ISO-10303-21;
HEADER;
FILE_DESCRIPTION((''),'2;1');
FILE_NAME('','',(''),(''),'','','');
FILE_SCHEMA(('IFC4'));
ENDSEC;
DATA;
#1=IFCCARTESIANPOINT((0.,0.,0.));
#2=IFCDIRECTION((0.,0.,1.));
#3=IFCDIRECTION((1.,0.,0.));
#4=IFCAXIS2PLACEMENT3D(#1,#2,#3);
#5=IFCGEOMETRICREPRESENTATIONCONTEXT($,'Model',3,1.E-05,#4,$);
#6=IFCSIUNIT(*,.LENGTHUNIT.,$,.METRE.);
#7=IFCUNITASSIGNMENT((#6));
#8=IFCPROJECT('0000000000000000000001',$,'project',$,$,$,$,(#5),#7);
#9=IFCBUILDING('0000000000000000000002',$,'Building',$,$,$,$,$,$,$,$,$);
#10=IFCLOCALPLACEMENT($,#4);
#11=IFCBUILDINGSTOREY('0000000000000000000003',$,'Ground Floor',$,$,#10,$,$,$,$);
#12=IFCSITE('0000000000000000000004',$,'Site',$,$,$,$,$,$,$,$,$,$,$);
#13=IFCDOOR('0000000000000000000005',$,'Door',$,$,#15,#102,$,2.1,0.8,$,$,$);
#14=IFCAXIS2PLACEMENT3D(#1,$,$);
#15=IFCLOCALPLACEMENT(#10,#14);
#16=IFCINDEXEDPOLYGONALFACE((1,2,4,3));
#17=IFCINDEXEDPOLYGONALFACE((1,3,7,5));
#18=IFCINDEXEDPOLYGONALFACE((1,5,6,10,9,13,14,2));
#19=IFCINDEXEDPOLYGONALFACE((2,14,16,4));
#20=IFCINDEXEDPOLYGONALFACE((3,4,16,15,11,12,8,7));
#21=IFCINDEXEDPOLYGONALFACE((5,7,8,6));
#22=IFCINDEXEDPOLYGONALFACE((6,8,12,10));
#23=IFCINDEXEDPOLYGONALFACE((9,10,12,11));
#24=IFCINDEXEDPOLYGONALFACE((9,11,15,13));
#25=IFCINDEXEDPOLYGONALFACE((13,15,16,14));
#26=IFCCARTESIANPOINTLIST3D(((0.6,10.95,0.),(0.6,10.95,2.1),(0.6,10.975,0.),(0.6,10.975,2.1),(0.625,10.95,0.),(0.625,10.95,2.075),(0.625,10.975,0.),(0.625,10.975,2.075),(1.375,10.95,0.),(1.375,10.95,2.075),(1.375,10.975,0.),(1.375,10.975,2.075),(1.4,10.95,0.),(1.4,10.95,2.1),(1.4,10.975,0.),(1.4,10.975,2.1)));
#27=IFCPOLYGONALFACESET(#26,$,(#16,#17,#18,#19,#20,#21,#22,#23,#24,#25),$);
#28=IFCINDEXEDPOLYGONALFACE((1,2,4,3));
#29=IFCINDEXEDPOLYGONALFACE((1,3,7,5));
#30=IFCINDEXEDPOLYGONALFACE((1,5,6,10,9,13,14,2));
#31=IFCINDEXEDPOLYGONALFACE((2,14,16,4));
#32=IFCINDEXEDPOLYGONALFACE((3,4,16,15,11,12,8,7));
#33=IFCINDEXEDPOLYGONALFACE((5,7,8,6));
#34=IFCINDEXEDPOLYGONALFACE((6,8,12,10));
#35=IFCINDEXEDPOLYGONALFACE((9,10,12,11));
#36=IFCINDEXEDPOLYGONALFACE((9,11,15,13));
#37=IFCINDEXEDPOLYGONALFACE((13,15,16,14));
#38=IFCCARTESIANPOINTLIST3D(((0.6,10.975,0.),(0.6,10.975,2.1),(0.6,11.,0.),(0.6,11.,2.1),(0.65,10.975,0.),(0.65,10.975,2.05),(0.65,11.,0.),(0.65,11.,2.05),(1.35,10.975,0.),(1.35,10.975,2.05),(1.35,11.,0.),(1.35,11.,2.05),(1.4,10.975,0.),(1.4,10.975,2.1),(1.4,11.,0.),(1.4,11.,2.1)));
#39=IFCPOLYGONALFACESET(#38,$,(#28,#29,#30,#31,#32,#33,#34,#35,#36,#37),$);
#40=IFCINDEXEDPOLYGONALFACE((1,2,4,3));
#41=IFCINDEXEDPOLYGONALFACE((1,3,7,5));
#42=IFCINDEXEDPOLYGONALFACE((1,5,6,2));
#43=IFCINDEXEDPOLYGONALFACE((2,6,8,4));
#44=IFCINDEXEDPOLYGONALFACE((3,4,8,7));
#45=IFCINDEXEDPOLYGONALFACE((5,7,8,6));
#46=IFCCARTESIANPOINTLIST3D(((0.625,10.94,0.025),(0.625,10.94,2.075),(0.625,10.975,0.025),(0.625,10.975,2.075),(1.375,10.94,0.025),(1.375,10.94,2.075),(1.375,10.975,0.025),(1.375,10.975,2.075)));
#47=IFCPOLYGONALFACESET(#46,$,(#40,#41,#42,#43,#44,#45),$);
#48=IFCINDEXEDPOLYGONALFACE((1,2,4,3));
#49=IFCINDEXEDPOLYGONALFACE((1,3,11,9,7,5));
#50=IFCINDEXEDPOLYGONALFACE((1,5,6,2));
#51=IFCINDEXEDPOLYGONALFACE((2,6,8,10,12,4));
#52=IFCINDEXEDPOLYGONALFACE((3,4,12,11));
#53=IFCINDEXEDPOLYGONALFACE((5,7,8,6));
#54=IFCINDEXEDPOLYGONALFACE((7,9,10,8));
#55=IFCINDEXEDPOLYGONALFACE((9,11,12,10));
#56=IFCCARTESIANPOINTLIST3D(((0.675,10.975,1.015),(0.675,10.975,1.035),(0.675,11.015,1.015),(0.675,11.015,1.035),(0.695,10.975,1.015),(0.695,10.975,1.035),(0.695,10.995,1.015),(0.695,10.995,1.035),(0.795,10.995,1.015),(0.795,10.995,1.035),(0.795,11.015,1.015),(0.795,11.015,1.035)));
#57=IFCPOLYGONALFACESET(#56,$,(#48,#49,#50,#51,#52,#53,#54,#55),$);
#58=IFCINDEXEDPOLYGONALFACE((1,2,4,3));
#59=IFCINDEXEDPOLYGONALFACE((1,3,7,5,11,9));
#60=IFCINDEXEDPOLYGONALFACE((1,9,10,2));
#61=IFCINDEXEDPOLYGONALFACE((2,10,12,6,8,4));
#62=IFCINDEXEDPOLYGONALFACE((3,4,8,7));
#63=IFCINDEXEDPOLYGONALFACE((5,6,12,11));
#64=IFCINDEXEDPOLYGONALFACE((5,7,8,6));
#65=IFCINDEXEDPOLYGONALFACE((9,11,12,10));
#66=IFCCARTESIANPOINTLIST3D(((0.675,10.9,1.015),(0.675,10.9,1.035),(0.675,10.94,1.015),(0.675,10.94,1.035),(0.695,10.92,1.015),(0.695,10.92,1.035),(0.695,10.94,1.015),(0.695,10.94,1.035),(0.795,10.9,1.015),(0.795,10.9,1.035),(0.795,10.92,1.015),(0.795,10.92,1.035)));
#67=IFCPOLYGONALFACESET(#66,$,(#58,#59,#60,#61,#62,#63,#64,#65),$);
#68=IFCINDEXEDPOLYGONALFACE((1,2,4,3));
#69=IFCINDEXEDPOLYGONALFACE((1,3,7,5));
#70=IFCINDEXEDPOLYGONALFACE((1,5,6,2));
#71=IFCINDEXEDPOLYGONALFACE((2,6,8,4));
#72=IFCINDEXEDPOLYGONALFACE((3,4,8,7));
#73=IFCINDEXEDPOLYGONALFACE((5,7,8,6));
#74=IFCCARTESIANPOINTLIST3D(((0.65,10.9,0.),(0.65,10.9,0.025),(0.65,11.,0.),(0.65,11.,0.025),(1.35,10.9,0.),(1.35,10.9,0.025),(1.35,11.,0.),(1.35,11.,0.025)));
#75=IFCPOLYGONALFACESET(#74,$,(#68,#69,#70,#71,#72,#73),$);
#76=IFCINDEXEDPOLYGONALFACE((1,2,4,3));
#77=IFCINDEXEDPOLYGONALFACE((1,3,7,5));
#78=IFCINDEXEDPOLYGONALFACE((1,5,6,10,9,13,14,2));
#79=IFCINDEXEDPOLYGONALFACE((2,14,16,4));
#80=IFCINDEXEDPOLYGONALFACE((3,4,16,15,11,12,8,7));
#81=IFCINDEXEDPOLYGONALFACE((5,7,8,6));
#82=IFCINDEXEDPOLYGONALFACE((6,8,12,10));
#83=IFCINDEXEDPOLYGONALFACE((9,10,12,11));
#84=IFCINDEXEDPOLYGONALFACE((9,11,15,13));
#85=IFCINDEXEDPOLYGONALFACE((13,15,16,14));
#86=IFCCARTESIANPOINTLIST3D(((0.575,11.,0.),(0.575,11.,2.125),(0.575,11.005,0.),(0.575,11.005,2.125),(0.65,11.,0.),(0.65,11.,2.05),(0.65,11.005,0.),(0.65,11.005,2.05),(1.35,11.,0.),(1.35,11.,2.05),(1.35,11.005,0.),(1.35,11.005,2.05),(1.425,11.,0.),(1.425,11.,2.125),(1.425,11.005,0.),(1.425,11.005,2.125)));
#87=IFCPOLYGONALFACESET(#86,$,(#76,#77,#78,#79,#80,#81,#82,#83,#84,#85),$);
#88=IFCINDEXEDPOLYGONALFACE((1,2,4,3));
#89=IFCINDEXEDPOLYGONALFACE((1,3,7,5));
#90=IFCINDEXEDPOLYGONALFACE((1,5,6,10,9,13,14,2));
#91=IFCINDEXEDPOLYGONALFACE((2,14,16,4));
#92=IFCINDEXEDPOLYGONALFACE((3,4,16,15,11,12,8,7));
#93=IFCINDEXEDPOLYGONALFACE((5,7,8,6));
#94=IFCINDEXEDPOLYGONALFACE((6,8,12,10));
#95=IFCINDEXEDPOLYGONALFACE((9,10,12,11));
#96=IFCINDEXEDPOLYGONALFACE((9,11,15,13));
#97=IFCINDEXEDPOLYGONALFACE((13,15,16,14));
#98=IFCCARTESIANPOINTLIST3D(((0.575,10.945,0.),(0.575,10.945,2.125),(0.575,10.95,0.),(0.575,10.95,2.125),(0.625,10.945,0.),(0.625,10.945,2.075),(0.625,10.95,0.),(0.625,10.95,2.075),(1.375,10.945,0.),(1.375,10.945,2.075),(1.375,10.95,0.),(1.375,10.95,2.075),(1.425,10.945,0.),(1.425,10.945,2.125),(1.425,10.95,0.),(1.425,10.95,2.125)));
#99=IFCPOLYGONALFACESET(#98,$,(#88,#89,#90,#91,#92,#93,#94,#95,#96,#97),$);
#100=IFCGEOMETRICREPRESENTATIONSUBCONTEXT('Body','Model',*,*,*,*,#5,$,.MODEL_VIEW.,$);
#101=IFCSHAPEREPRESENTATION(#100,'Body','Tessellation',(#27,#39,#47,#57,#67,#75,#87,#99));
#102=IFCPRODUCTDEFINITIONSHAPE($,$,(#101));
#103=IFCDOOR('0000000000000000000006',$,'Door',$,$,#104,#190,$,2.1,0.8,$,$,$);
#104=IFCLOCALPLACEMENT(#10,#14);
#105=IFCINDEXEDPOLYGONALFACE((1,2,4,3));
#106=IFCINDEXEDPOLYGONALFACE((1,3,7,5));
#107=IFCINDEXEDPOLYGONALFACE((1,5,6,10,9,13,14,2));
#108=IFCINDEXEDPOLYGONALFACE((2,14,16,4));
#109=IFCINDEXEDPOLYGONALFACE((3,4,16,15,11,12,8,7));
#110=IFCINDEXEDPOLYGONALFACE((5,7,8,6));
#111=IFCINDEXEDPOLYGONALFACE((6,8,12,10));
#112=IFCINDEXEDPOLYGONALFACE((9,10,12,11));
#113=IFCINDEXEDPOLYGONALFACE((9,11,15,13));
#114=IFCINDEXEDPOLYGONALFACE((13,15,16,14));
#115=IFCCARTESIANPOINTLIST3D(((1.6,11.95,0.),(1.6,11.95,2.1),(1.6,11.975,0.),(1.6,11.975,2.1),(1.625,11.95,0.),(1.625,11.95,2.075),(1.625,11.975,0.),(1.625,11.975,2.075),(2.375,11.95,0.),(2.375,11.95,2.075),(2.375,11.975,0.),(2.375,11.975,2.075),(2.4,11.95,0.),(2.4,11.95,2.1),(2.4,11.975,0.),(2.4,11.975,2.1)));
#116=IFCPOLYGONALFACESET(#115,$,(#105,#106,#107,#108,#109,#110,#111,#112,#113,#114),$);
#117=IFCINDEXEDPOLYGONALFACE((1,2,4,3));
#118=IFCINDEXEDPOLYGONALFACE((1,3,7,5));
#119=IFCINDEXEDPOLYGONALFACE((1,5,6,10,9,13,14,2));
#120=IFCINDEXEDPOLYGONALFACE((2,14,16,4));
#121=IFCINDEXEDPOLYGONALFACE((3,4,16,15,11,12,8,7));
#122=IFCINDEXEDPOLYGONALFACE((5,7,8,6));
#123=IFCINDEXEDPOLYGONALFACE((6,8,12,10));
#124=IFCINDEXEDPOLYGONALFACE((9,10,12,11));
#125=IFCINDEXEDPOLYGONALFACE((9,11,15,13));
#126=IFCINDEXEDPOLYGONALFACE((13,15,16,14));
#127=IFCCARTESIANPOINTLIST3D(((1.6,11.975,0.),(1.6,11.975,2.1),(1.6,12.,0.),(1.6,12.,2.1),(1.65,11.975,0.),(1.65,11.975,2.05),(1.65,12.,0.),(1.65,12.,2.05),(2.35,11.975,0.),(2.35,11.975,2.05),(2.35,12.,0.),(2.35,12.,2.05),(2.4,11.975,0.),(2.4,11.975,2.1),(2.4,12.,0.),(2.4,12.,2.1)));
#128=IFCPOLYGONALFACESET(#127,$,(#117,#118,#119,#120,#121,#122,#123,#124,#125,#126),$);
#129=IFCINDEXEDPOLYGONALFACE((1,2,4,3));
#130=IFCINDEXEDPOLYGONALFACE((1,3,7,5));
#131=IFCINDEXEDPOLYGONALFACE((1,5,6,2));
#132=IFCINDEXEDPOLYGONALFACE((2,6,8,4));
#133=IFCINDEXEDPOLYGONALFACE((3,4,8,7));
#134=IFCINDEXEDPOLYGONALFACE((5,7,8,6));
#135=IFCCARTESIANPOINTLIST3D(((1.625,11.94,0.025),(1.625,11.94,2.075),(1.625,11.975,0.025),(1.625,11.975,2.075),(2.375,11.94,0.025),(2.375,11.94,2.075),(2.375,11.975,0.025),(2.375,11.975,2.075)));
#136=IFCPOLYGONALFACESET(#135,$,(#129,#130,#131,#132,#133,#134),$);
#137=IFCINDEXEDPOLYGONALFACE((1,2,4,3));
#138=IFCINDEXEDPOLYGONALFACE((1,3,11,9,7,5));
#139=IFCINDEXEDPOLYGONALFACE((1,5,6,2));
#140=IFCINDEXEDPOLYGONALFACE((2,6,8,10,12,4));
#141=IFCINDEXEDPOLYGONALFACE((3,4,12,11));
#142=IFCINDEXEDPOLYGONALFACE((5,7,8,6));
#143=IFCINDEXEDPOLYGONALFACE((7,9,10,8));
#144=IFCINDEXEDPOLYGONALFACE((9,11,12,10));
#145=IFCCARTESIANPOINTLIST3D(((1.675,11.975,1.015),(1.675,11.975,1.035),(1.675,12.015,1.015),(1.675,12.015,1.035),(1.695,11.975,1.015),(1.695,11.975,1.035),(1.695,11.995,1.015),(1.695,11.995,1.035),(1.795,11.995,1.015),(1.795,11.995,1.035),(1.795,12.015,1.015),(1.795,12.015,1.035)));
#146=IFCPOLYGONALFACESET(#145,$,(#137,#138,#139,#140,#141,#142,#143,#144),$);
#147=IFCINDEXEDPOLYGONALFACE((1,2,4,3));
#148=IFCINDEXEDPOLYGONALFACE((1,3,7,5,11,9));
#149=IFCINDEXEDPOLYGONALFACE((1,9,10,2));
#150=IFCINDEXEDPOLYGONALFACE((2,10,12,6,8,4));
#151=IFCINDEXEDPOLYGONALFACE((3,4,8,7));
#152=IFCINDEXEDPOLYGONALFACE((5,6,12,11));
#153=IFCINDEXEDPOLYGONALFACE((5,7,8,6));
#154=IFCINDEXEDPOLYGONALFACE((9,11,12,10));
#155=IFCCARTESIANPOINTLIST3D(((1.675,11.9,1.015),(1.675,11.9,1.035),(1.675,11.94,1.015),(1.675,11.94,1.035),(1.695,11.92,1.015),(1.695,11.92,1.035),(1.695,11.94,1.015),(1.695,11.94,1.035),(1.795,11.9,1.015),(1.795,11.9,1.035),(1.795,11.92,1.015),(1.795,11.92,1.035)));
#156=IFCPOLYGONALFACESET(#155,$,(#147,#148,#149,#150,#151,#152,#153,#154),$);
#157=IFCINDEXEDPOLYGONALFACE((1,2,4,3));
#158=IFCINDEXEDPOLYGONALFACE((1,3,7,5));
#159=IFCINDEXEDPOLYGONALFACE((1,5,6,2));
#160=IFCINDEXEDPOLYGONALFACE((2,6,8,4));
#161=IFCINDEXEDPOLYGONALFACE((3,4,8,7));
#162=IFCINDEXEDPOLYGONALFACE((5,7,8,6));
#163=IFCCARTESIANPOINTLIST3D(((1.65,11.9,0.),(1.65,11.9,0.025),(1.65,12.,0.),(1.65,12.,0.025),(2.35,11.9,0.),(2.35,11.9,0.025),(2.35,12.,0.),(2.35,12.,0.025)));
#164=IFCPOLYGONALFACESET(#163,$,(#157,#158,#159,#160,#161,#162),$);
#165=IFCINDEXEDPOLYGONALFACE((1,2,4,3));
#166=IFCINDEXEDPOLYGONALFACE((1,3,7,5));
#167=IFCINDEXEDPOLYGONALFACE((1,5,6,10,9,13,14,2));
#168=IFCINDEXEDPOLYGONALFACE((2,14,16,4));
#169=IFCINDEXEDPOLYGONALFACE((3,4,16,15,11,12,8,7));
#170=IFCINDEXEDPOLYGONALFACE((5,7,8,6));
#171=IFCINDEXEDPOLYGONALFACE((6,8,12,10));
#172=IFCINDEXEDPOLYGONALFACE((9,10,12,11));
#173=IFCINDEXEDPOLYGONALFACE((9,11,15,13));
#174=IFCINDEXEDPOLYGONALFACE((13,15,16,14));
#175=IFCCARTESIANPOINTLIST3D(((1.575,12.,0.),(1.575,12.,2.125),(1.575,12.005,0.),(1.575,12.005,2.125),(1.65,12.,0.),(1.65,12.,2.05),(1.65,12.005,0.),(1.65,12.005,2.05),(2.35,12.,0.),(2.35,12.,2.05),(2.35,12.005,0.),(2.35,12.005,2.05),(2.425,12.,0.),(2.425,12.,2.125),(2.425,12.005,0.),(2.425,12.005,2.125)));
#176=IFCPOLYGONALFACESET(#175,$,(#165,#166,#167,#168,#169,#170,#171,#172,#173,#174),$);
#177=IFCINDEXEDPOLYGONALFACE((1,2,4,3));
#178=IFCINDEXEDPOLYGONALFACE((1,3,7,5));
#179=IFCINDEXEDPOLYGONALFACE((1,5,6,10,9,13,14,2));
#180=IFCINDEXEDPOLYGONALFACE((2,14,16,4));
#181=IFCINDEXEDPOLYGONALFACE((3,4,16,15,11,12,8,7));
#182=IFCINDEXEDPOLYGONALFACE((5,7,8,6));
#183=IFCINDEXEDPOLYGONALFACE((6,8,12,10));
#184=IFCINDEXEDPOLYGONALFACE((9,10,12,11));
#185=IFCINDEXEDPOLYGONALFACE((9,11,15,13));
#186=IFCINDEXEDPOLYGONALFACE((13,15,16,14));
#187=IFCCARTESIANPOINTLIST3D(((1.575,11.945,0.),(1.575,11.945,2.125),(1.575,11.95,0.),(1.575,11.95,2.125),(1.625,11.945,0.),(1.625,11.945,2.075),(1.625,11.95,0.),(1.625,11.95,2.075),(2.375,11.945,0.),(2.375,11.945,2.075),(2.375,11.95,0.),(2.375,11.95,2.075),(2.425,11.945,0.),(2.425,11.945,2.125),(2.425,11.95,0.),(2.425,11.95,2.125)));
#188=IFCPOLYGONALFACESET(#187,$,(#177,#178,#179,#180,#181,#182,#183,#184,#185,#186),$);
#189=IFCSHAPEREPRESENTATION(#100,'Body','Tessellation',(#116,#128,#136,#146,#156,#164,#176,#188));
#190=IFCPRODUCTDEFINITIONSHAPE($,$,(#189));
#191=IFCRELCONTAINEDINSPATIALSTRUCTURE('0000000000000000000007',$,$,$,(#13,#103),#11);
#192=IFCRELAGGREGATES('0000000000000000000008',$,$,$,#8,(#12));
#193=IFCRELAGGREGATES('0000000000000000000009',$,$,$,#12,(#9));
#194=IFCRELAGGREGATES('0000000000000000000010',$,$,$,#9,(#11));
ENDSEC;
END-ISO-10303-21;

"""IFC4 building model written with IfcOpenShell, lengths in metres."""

from ifc_helpers import new_model, si_unit, frame, origin_with_axes, place, context, subcontext, project, spatial, line, indexed_curve, outline, extrude, element, save


model = new_model("IFC4")

# Units and contexts
model_context = context("Model", 3, precision=1e-05, world=origin_with_axes())
body_context = subcontext(model_context, "Body", "Model", "MODEL_VIEW")
ifc_project = project(units=[si_unit("LENGTHUNIT", "METRE")], contexts=[model_context])

# Site, building, storey
site = spatial("IfcSite", under=ifc_project, Name="Site")
building = spatial("IfcBuilding", under=site, Name="Building")
storey_placement = place(None, origin_with_axes())
storey = spatial("IfcBuildingStorey", under=building, at=storey_placement, Name="Ground Floor")

# Doors
door_1_placement = place(storey_placement, frame((1.4, 11.0, 0.0), z_axis=(0.0, 0.0, 1.0), x_axis=(-1.0, 0.0, 0.0)))
element("IfcDoor", 1, at=door_1_placement, inside=storey, Name="Door", OverallHeight=2.1, OverallWidth=0.8, context=body_context, shape_type="SweptSolid", body=[
    extrude(outline(indexed_curve([(0.0, 0.0), (0.0, 2.1), (0.8, 2.1), (0.8, 0.0), (0.775, 0.0), (0.775, 2.075), (0.025, 2.075), (0.025, 0.0)], segments=[line(1, 2, 3, 4, 5, 6, 7, 8, 1)])), frame((0.0, 0.025, 0.0), z_axis=(0.0, -1.0, 0.0), x_axis=(1.0, 0.0, 0.0)), (0.0, 0.0, -1.0), 0.025),
    extrude(outline(indexed_curve([(0.0, 0.0), (0.0, 2.1), (0.8, 2.1), (0.8, 0.0), (0.75, 0.0), (0.75, 2.05), (0.05, 2.05), (0.05, 0.0)], segments=[line(1, 2, 3, 4, 5, 6, 7, 8, 1)])), frame((0.0, 0.0, 0.0), z_axis=(0.0, -1.0, 0.0), x_axis=(1.0, 0.0, 0.0)), (0.0, 0.0, -1.0), 0.025),
    extrude(outline(indexed_curve([(0.0, 0.0), (0.75, 0.0), (0.75, 0.035), (0.0, 0.035)], segments=[line(1, 2, 3, 4, 1)])), frame((0.025, 0.025, 0.025), z_axis=(0.0, 0.0, 1.0), x_axis=(1.0, 0.0, 0.0)), (0.0, 0.0, 1.0), 2.05),
    extrude(outline(indexed_curve([(0.0, 0.0), (0.0, -0.04), (-0.12, -0.04), (-0.12, -0.02), (-0.02, -0.02), (-0.02, 0.0)], segments=[line(1, 2, 3, 4, 5, 6, 1)])), frame((0.725, 0.025, 1.015), z_axis=(0.0, 0.0, 1.0), x_axis=(1.0, 0.0, 0.0)), (0.0, 0.0, 1.0), 0.02),
    extrude(outline(indexed_curve([(0.0, 0.0), (0.0, 0.04), (-0.12, 0.04), (-0.12, 0.02), (-0.02, 0.02), (-0.02, 0.0)], segments=[line(1, 2, 3, 4, 5, 6, 1)])), frame((0.725, 0.06, 1.015), z_axis=(0.0, 0.0, 1.0), x_axis=(1.0, 0.0, 0.0)), (0.0, 0.0, 1.0), 0.02),
    extrude(outline(indexed_curve([(0.0, 0.0), (0.7, 0.0), (0.7, 0.1), (0.0, 0.1)], segments=[line(1, 2, 3, 4, 1)])), frame((0.05, 0.0, 0.0), z_axis=(0.0, 0.0, 1.0), x_axis=(1.0, 0.0, 0.0)), (0.0, 0.0, 1.0), 0.025),
    extrude(outline(indexed_curve([(0.0, 0.0), (0.0, 2.125), (0.85, 2.125), (0.85, 0.0), (0.775, 0.0), (0.775, 2.05), (0.075, 2.05), (0.075, 0.0)], segments=[line(1, 2, 3, 4, 5, 6, 7, 8, 1)])), frame((-0.025, -0.005, 0.0), z_axis=(0.0, -1.0, 0.0), x_axis=(1.0, 0.0, 0.0)), (0.0, 0.0, -1.0), 0.005),
    extrude(outline(indexed_curve([(0.0, 0.0), (0.0, 2.125), (0.85, 2.125), (0.85, 0.0), (0.8, 0.0), (0.8, 2.075), (0.05, 2.075), (0.05, 0.0)], segments=[line(1, 2, 3, 4, 5, 6, 7, 8, 1)])), frame((-0.025, 0.05, 0.0), z_axis=(0.0, -1.0, 0.0), x_axis=(1.0, 0.0, 0.0)), (0.0, 0.0, -1.0), 0.005),
])
door_2_placement = place(storey_placement, frame((2.4, 12.0, 0.0), z_axis=(0.0, 0.0, 1.0), x_axis=(-1.0, 0.0, 0.0)))
element("IfcDoor", 2, at=door_2_placement, inside=storey, Name="Door", OverallHeight=2.1, OverallWidth=0.8, context=body_context, shape_type="SweptSolid", body=[
    extrude(outline(indexed_curve([(0.0, 0.0), (0.0, 2.1), (0.8, 2.1), (0.8, 0.0), (0.775, 0.0), (0.775, 2.075), (0.025, 2.075), (0.025, 0.0)], segments=[line(1, 2, 3, 4, 5, 6, 7, 8, 1)])), frame((0.0, 0.025, 0.0), z_axis=(0.0, -1.0, 0.0), x_axis=(1.0, 0.0, 0.0)), (0.0, 0.0, -1.0), 0.025),
    extrude(outline(indexed_curve([(0.0, 0.0), (0.0, 2.1), (0.8, 2.1), (0.8, 0.0), (0.75, 0.0), (0.75, 2.05), (0.05, 2.05), (0.05, 0.0)], segments=[line(1, 2, 3, 4, 5, 6, 7, 8, 1)])), frame((0.0, 0.0, 0.0), z_axis=(0.0, -1.0, 0.0), x_axis=(1.0, 0.0, 0.0)), (0.0, 0.0, -1.0), 0.025),
    extrude(outline(indexed_curve([(0.0, 0.0), (0.75, 0.0), (0.75, 0.035), (0.0, 0.035)], segments=[line(1, 2, 3, 4, 1)])), frame((0.025, 0.025, 0.025), z_axis=(0.0, 0.0, 1.0), x_axis=(1.0, 0.0, 0.0)), (0.0, 0.0, 1.0), 2.05),
    extrude(outline(indexed_curve([(0.0, 0.0), (0.0, -0.04), (-0.12, -0.04), (-0.12, -0.02), (-0.02, -0.02), (-0.02, 0.0)], segments=[line(1, 2, 3, 4, 5, 6, 1)])), frame((0.725, 0.025, 1.015), z_axis=(0.0, 0.0, 1.0), x_axis=(1.0, 0.0, 0.0)), (0.0, 0.0, 1.0), 0.02),
    extrude(outline(indexed_curve([(0.0, 0.0), (0.0, 0.04), (-0.12, 0.04), (-0.12, 0.02), (-0.02, 0.02), (-0.02, 0.0)], segments=[line(1, 2, 3, 4, 5, 6, 1)])), frame((0.725, 0.06, 1.015), z_axis=(0.0, 0.0, 1.0), x_axis=(1.0, 0.0, 0.0)), (0.0, 0.0, 1.0), 0.02),
    extrude(outline(indexed_curve([(0.0, 0.0), (0.7, 0.0), (0.7, 0.1), (0.0, 0.1)], segments=[line(1, 2, 3, 4, 1)])), frame((0.05, 0.0, 0.0), z_axis=(0.0, 0.0, 1.0), x_axis=(1.0, 0.0, 0.0)), (0.0, 0.0, 1.0), 0.025),
    extrude(outline(indexed_curve([(0.0, 0.0), (0.0, 2.125), (0.85, 2.125), (0.85, 0.0), (0.775, 0.0), (0.775, 2.05), (0.075, 2.05), (0.075, 0.0)], segments=[line(1, 2, 3, 4, 5, 6, 7, 8, 1)])), frame((-0.025, -0.005, 0.0), z_axis=(0.0, -1.0, 0.0), x_axis=(1.0, 0.0, 0.0)), (0.0, 0.0, -1.0), 0.005),
    extrude(outline(indexed_curve([(0.0, 0.0), (0.0, 2.125), (0.85, 2.125), (0.85, 0.0), (0.8, 0.0), (0.8, 2.075), (0.05, 2.075), (0.05, 0.0)], segments=[line(1, 2, 3, 4, 5, 6, 7, 8, 1)])), frame((-0.025, 0.05, 0.0), z_axis=(0.0, -1.0, 0.0), x_axis=(1.0, 0.0, 0.0)), (0.0, 0.0, -1.0), 0.005),
])

save(model, "model.ifc")
